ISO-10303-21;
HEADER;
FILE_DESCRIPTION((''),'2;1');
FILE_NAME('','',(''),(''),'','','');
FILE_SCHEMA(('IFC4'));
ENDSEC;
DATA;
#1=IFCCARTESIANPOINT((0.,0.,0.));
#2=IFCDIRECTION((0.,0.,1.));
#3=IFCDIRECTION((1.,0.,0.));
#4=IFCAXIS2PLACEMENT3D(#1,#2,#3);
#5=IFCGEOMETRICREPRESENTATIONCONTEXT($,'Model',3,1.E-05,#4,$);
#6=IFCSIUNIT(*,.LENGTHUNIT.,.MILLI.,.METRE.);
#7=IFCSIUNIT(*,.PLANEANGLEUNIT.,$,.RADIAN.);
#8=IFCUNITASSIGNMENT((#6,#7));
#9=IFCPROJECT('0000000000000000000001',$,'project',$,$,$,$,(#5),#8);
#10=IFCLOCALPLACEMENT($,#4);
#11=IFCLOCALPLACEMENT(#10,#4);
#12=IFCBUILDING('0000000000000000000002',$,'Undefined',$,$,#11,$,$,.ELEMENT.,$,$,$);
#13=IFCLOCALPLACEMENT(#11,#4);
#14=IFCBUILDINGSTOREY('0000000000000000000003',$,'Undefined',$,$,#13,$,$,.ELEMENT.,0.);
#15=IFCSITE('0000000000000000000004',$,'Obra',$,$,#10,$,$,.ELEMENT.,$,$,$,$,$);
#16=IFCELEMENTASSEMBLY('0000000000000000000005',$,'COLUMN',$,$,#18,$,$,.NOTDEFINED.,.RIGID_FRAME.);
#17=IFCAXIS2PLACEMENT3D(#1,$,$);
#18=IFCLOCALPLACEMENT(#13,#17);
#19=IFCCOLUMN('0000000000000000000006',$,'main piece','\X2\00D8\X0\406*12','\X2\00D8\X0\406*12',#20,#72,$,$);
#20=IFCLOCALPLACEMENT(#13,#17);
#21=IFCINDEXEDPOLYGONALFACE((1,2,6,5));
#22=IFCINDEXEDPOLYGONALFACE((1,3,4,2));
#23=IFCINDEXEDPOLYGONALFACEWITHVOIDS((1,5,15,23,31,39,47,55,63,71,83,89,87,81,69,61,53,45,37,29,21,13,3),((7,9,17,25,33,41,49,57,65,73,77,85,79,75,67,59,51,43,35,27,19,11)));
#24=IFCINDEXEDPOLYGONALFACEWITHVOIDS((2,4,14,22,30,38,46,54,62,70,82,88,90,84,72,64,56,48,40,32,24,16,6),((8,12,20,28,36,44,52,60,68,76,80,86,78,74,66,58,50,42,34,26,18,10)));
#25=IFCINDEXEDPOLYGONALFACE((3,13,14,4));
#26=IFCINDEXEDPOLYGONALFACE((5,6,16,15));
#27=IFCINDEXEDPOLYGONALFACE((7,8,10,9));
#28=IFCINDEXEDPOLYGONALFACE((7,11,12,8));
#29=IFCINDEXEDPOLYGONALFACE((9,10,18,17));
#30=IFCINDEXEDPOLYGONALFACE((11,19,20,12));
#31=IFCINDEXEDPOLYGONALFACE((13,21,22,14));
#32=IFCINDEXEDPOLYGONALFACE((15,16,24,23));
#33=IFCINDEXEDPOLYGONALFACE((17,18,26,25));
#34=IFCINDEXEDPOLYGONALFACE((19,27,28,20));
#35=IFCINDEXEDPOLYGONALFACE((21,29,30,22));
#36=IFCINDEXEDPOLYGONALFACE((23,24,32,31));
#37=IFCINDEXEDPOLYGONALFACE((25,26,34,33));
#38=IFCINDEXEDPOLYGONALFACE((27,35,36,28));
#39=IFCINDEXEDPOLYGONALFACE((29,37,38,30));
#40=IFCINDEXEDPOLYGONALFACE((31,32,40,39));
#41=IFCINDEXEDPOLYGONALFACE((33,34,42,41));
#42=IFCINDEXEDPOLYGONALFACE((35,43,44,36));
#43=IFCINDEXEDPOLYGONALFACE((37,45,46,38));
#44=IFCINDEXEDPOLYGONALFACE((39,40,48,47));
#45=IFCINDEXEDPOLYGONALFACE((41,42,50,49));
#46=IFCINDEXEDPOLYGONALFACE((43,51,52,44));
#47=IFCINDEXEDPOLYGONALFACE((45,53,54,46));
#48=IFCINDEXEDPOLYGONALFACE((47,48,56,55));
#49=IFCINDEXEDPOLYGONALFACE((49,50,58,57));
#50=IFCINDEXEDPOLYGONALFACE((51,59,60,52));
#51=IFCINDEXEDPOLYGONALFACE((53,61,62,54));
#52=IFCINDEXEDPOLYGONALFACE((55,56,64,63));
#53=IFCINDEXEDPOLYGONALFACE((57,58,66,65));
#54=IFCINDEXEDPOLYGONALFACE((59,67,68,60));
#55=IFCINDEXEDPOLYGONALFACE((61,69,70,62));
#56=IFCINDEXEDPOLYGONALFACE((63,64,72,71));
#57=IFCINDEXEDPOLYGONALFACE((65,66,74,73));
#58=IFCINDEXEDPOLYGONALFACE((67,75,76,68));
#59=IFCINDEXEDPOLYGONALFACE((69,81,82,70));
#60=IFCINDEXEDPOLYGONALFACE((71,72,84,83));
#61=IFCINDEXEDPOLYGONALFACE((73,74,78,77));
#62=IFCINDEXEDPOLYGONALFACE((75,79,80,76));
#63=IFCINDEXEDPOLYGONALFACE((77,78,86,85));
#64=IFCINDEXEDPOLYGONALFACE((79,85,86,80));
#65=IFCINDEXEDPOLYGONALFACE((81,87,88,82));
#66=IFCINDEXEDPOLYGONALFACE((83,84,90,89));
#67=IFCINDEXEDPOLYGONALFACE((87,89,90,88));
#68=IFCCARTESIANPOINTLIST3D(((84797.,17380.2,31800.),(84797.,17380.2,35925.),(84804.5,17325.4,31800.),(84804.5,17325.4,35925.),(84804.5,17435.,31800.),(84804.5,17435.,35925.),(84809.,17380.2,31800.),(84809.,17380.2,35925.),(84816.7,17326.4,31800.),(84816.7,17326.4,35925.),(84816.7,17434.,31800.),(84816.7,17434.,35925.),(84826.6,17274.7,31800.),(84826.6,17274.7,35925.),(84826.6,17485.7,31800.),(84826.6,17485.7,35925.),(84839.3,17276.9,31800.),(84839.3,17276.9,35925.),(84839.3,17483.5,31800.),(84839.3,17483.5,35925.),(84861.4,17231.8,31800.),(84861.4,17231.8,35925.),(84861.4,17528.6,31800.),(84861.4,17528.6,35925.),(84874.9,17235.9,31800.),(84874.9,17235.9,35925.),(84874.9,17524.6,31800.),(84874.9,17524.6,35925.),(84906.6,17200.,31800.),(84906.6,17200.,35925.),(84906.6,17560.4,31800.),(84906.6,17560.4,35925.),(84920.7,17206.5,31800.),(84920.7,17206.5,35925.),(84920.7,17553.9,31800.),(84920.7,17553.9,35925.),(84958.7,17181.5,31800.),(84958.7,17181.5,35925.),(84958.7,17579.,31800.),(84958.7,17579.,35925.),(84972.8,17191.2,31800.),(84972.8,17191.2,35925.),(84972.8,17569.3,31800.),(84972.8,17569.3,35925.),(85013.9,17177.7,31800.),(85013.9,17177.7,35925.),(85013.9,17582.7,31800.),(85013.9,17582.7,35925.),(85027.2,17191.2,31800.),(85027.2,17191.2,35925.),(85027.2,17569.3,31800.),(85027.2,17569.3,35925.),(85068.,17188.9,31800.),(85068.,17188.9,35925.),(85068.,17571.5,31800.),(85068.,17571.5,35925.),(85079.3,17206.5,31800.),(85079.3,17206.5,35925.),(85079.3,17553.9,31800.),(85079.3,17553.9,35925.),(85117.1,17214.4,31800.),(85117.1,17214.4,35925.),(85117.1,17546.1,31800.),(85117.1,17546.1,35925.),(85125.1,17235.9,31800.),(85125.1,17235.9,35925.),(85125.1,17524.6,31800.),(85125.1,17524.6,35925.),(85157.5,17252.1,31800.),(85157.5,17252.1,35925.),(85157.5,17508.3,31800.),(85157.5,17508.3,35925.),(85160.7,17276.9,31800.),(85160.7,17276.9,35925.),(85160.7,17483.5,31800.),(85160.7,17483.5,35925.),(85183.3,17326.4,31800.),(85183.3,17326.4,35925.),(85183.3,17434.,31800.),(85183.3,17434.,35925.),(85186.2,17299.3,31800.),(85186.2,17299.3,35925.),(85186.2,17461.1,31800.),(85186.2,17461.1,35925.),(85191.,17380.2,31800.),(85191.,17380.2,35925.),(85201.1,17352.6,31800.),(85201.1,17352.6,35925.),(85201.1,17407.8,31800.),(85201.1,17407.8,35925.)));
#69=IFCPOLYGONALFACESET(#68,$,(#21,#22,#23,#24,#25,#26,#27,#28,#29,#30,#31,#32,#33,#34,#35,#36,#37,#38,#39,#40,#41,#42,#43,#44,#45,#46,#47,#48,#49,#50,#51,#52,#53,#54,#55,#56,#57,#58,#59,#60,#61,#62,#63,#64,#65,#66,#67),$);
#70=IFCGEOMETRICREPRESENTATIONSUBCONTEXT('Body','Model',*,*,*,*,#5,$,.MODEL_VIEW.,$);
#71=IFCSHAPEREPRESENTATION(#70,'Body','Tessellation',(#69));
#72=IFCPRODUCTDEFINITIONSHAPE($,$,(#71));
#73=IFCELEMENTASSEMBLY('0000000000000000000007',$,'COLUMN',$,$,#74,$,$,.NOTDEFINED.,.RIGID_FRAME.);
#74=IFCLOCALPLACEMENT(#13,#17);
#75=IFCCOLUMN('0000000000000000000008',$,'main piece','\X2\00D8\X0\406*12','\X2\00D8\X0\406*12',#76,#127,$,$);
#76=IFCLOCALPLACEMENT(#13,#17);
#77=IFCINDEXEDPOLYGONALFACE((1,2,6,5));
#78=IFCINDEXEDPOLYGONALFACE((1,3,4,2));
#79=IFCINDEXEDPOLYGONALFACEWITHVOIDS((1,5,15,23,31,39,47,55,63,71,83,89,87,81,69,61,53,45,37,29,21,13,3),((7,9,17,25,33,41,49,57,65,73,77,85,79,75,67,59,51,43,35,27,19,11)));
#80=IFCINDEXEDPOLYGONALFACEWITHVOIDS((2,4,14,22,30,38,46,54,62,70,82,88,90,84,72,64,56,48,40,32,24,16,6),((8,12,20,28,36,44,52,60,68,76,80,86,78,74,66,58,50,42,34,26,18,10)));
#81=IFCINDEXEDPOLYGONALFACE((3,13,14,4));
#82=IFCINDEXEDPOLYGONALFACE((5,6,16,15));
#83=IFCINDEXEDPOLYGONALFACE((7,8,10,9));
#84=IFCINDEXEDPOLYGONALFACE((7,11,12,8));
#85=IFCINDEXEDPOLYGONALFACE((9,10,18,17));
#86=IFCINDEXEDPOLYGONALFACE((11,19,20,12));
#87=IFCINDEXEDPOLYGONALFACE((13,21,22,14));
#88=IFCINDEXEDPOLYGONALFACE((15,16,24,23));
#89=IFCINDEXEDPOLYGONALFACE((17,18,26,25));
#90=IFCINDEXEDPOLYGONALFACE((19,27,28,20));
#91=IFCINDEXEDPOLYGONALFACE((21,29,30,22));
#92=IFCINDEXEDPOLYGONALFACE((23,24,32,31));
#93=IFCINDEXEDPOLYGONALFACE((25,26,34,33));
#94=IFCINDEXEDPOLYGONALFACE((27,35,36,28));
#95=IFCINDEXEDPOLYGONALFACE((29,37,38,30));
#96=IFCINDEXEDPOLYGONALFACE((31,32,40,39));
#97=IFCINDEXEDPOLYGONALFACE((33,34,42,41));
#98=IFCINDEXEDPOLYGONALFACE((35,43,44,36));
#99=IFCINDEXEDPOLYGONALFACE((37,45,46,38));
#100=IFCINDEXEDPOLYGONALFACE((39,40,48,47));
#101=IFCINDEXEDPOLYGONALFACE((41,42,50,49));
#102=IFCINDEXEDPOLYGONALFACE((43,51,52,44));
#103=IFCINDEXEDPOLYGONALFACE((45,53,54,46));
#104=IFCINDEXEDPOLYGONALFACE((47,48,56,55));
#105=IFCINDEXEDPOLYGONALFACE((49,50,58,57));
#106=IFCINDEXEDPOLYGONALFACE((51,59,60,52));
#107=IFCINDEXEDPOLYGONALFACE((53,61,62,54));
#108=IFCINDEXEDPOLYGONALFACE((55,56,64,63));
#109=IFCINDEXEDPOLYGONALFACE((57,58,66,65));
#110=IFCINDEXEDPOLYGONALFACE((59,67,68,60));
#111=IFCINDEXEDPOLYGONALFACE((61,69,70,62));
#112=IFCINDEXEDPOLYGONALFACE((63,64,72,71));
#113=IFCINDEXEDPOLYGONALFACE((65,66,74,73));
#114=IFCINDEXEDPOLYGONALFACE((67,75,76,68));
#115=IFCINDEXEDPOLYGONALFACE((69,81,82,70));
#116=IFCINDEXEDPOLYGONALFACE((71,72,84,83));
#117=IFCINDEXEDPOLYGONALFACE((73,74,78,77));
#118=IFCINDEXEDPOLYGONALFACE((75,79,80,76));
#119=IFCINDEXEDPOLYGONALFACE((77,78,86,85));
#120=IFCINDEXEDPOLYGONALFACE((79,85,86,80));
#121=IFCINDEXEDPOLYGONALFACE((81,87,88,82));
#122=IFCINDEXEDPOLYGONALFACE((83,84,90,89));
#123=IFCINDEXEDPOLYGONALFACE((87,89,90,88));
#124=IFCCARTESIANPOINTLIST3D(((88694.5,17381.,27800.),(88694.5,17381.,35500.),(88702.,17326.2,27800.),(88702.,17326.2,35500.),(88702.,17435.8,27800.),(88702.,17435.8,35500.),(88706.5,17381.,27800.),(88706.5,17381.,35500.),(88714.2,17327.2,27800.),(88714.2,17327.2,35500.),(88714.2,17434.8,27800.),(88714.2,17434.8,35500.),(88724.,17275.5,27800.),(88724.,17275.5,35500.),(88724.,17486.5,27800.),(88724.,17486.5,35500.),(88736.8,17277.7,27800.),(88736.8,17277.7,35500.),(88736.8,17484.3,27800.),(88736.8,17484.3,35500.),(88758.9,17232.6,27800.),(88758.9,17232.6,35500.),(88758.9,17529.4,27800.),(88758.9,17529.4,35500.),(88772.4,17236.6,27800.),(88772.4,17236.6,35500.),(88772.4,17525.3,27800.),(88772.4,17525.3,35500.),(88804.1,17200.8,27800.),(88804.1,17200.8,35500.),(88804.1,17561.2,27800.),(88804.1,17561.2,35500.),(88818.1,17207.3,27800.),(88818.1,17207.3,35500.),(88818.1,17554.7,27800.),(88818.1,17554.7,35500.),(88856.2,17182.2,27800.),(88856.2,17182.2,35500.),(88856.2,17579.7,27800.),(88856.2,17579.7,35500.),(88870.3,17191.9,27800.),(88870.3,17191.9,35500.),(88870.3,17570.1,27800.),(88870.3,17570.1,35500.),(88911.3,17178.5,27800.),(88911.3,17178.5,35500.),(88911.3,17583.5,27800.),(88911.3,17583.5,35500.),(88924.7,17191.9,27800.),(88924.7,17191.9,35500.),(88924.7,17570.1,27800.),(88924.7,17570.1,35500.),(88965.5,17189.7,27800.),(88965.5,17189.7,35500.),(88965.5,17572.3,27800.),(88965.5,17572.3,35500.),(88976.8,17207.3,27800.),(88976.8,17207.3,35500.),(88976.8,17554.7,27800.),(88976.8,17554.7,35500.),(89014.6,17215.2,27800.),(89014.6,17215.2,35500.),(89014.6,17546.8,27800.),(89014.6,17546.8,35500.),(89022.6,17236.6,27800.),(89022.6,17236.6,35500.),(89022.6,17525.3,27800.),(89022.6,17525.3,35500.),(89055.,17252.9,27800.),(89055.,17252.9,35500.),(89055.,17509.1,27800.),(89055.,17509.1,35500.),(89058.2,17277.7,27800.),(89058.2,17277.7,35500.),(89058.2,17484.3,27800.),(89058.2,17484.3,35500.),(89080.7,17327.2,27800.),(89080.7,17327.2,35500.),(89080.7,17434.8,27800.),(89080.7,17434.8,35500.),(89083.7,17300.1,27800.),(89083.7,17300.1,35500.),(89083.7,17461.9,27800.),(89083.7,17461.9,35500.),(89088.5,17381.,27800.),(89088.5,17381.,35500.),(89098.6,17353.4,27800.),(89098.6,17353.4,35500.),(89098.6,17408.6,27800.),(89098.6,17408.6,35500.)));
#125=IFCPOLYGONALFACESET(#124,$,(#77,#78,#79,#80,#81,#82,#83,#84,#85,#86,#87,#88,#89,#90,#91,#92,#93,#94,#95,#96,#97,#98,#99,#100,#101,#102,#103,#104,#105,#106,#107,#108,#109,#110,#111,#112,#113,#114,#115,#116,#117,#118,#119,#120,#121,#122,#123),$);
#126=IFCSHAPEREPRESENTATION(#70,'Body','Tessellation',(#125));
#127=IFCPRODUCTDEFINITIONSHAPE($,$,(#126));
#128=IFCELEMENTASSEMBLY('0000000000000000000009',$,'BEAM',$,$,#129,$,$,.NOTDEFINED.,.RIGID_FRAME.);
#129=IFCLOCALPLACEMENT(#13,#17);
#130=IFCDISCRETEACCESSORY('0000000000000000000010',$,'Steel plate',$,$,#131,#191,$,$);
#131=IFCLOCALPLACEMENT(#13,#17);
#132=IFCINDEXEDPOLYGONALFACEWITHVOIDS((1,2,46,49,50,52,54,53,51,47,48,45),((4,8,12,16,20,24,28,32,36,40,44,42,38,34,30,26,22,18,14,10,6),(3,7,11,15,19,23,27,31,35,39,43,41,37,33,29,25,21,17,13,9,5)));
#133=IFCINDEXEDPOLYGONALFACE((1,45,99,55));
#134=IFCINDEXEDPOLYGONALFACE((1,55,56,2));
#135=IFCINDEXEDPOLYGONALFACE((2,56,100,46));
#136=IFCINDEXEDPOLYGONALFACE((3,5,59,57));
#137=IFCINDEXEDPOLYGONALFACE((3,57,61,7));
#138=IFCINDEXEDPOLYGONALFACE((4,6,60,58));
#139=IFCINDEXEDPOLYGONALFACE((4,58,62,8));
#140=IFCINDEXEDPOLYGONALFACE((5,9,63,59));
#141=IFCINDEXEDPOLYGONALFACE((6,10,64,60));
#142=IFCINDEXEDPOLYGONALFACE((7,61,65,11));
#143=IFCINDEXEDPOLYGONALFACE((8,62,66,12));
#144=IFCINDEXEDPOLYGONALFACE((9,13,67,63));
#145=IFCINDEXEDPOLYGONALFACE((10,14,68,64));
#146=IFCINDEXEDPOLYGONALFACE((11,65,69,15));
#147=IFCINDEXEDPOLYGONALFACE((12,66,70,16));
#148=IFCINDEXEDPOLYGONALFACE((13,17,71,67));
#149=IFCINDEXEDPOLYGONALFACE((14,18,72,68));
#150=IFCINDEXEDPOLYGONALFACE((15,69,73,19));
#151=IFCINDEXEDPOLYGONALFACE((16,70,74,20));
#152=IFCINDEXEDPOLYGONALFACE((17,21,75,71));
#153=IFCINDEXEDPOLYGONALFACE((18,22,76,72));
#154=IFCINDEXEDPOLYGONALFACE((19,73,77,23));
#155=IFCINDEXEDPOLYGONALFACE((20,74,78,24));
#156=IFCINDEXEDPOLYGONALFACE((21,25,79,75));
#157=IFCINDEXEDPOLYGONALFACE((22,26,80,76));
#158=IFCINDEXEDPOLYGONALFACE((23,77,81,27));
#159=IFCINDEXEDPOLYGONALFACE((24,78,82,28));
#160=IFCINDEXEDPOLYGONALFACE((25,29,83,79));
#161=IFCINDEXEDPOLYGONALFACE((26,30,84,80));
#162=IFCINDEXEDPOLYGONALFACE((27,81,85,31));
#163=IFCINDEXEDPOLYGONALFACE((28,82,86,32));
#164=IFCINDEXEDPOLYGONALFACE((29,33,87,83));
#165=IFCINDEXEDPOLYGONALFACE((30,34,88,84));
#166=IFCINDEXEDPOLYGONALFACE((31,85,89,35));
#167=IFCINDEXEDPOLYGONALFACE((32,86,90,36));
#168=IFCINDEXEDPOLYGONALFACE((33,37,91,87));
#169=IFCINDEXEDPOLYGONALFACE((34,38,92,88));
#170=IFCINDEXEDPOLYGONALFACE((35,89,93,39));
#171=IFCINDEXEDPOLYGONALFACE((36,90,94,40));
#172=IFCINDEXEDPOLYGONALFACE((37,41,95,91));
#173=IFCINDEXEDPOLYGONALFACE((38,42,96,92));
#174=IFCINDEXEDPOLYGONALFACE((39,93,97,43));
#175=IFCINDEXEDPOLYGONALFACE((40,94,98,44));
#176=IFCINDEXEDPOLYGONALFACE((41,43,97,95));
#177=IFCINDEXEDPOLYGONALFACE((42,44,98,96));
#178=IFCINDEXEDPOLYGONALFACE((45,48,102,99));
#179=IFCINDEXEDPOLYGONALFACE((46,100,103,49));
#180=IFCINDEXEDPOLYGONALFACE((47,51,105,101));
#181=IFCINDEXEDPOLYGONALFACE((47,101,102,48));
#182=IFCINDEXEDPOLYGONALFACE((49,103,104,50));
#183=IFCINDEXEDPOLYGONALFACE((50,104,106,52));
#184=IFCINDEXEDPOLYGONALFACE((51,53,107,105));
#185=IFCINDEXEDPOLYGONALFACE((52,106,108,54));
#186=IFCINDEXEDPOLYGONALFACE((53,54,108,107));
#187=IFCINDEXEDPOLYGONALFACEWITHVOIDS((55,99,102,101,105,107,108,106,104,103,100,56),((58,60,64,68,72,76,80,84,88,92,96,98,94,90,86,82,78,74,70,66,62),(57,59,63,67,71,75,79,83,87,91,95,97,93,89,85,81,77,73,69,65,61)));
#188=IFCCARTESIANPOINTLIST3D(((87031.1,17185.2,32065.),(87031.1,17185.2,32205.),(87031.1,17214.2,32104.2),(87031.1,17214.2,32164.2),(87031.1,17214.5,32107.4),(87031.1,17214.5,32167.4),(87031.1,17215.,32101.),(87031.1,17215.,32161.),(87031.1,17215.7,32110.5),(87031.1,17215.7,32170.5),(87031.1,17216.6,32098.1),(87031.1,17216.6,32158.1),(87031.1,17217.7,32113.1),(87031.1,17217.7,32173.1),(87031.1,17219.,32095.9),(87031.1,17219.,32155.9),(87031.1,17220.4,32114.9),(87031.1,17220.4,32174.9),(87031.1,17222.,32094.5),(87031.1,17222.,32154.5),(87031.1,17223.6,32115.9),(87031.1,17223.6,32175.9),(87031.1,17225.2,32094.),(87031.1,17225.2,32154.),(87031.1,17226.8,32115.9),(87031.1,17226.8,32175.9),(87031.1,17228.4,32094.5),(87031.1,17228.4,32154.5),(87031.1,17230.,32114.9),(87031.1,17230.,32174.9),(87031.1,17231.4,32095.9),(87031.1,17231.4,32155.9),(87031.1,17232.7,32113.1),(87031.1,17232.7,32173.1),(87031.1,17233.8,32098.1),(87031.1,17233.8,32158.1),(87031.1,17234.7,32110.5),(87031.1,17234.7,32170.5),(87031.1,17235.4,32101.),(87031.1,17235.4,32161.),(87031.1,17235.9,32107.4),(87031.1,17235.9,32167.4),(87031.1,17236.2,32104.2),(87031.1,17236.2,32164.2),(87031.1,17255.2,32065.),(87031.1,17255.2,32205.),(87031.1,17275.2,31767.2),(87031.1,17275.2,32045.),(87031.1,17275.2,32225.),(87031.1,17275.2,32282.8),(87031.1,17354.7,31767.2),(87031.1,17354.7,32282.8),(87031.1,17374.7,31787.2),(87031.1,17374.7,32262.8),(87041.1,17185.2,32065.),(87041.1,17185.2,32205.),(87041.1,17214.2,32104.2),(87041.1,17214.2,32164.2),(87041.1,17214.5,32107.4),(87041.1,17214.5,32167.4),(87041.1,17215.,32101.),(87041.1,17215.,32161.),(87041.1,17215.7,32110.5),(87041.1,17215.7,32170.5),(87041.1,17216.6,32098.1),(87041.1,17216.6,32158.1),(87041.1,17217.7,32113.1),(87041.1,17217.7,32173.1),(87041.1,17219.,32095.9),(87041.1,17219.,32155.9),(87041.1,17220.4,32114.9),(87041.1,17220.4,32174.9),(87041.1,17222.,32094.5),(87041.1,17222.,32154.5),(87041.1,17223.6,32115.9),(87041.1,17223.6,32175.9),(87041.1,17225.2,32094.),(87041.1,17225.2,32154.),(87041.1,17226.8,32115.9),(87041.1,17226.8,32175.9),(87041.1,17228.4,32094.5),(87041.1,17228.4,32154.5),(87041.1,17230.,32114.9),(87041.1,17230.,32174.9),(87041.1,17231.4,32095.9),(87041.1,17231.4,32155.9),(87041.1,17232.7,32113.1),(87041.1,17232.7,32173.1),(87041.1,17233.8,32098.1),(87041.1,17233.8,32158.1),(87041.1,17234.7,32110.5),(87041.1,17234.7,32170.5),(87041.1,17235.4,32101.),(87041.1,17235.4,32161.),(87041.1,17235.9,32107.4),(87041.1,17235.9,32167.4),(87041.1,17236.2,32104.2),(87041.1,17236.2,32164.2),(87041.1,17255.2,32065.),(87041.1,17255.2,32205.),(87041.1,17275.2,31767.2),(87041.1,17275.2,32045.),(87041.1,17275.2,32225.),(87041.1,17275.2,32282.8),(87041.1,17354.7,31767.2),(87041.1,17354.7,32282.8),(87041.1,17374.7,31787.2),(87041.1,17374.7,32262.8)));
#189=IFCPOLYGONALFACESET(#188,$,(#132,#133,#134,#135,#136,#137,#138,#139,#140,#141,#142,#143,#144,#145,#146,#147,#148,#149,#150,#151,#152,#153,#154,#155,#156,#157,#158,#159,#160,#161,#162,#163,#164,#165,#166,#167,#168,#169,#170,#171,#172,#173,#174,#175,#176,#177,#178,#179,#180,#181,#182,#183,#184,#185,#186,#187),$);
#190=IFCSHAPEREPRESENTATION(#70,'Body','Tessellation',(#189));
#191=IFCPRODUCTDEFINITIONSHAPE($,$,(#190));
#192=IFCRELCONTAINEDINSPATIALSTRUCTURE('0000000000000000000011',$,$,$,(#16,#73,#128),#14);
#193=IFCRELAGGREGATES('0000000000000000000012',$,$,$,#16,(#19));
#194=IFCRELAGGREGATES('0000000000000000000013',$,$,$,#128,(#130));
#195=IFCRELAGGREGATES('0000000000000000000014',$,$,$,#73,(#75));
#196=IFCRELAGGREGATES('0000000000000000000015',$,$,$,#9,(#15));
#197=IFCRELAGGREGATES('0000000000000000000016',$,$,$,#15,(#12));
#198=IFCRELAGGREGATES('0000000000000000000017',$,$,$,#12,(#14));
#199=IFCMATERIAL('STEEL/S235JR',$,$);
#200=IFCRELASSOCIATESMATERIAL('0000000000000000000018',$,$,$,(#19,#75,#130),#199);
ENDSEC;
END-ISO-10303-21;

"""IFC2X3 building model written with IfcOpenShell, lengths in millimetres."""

from ifc_helpers import new_model, si_unit, frame, origin_with_axes, origin_2d_with_axis, place, context, subcontext, project, spatial, polyline, circle, hollow_circle, outline, extrude, source, transform, mapped, material, element, aggregate, save


model = new_model("IFC2X3")

# Units and contexts
model_context = context("Model", 3, precision=1e-05, world=origin_with_axes())
body_context = subcontext(model_context, "Body", "Model", "MODEL_VIEW")
ifc_project = project(units=[si_unit("LENGTHUNIT", "METRE", prefix="MILLI"), si_unit("PLANEANGLEUNIT", "RADIAN")], contexts=[model_context])

# Site, building, storey
site_placement = place(None, origin_with_axes())
site = spatial("IfcSite", under=ifc_project, at=site_placement, Name="Obra", CompositionType="ELEMENT")
building_placement = place(site_placement, origin_with_axes())
building = spatial("IfcBuilding", under=site, at=building_placement, Name="Undefined", CompositionType="ELEMENT")
storey_placement = place(building_placement, origin_with_axes())
storey = spatial("IfcBuildingStorey", under=building, at=storey_placement, Name="Undefined", CompositionType="ELEMENT", Elevation=0.0)

# Element assemblies, columns
assembly_1_placement = place(storey_placement, origin_with_axes())
assembly_1 = element("IfcElementAssembly", 1, at=assembly_1_placement, inside=storey, Name="COLUMN", AssemblyPlace="NOTDEFINED", PredefinedType="RIGID_FRAME")
ifc_material_1 = material(Name="STEEL/S235JR")
column_1_placement = place(assembly_1_placement, frame((85000.0, 17380.2, 31800.0), z_axis=(0.0, 0.0, 1.0), x_axis=(0.0, 1.0, 0.0)))
column_1 = element("IfcColumn", 2, at=column_1_placement, material=ifc_material_1, Name="main piece", Description="Ø406*12", ObjectType="Ø406*12", context=body_context, shape_type="SweptSolid", body=[
    extrude(hollow_circle(Radius=203.0, WallThickness=12.0, at=origin_2d_with_axis()), frame((0.0, 0.0, 4125.0), z_axis=(0.0, 0.0, -1.0), x_axis=(0.0, 1.0, 0.0)), (0.0, 0.0, 1.0), 4125.0),
])
assembly_2_placement = place(storey_placement, origin_with_axes())
assembly_2 = element("IfcElementAssembly", 3, at=assembly_2_placement, inside=storey, Name="COLUMN", AssemblyPlace="NOTDEFINED", PredefinedType="RIGID_FRAME")
column_2_placement = place(assembly_2_placement, frame((88897.5, 17381.0, 27800.0), z_axis=(0.0, 0.0, 1.0), x_axis=(0.0, 1.0, 0.0)))
column_2 = element("IfcColumn", 4, at=column_2_placement, material=ifc_material_1, Name="main piece", Description="Ø406*12", ObjectType="Ø406*12", context=body_context, shape_type="SweptSolid", body=[
    extrude(hollow_circle(Radius=203.0, WallThickness=12.0, at=origin_2d_with_axis()), frame((0.0, 0.0, 7700.0), z_axis=(0.0, 0.0, -1.0), x_axis=(0.0, 1.0, 0.0)), (0.0, 0.0, 1.0), 7700.0),
])

# Element assembly
assembly_3_placement = place(storey_placement, origin_with_axes())
assembly_3 = element("IfcElementAssembly", 5, at=assembly_3_placement, inside=storey, Name="BEAM", AssemblyPlace="NOTDEFINED", PredefinedType="RIGID_FRAME")

# Discrete accessory, opening
aggregate(assembly_1, [column_1])
discrete_accessory_1_placement = place(assembly_3_placement, frame((87036.1, 17374.7, 31787.2), z_axis=(-1.0, 0.0, 0.0), x_axis=(0.0, -0.707107, -0.707107)))
discrete_accessory_1 = element("IfcDiscreteAccessory", 6, at=discrete_accessory_1_placement, material=ifc_material_1, Name="Steel plate", context=body_context, shape_type="SweptSolid", body=[
    extrude(outline(polyline([(0.0, 0.0), (28.3, 0.0), (84.5, 56.2), (-112.0, 252.6), (-112.0, 280.9), (-62.5, 330.4), (-161.5, 429.4), (-211.0, 379.9), (-239.2, 379.9), (-280.1, 420.8), (-336.3, 364.6), (-336.3, 336.3), (0.0, 0.0)])), frame((0.0, 0.0, -5.0), z_axis=(0.0, 0.0, 1.0), x_axis=(1.0, 0.0, 0.0)), (0.0, 0.0, 1.0), 10.0),
])
shared_shape_1 = source(origin_with_axes(), body_context, "Body", "SweptSolid", [
    extrude(circle(Radius=11.0, at=origin_2d_with_axis()), frame((0.0, -13.9, 0.0), z_axis=(0.0, 1.0, 0.0), x_axis=(1.0, 0.0, 0.0)), (0.0, 0.0, 1.0), 10.2),
])
opening_1_placement = place(assembly_3_placement, frame((87044.8, 17265.2, 32205.0), z_axis=(0.0, -1.0, 0.0), x_axis=(0.0, 0.0, -1.0)))
element("IfcOpeningElement", 7, at=opening_1_placement, cuts=discrete_accessory_1, ObjectType="Opening", context=body_context, shape_type="MappedRepresentation", body=[
    mapped(shared_shape_1, transform((40.0, 0.0, 40.0))),
    mapped(shared_shape_1, transform((100.0, 0.0, 40.0))),
])
aggregate(assembly_3, [discrete_accessory_1])
aggregate(assembly_2, [column_2])

save(model, "model.ifc")
